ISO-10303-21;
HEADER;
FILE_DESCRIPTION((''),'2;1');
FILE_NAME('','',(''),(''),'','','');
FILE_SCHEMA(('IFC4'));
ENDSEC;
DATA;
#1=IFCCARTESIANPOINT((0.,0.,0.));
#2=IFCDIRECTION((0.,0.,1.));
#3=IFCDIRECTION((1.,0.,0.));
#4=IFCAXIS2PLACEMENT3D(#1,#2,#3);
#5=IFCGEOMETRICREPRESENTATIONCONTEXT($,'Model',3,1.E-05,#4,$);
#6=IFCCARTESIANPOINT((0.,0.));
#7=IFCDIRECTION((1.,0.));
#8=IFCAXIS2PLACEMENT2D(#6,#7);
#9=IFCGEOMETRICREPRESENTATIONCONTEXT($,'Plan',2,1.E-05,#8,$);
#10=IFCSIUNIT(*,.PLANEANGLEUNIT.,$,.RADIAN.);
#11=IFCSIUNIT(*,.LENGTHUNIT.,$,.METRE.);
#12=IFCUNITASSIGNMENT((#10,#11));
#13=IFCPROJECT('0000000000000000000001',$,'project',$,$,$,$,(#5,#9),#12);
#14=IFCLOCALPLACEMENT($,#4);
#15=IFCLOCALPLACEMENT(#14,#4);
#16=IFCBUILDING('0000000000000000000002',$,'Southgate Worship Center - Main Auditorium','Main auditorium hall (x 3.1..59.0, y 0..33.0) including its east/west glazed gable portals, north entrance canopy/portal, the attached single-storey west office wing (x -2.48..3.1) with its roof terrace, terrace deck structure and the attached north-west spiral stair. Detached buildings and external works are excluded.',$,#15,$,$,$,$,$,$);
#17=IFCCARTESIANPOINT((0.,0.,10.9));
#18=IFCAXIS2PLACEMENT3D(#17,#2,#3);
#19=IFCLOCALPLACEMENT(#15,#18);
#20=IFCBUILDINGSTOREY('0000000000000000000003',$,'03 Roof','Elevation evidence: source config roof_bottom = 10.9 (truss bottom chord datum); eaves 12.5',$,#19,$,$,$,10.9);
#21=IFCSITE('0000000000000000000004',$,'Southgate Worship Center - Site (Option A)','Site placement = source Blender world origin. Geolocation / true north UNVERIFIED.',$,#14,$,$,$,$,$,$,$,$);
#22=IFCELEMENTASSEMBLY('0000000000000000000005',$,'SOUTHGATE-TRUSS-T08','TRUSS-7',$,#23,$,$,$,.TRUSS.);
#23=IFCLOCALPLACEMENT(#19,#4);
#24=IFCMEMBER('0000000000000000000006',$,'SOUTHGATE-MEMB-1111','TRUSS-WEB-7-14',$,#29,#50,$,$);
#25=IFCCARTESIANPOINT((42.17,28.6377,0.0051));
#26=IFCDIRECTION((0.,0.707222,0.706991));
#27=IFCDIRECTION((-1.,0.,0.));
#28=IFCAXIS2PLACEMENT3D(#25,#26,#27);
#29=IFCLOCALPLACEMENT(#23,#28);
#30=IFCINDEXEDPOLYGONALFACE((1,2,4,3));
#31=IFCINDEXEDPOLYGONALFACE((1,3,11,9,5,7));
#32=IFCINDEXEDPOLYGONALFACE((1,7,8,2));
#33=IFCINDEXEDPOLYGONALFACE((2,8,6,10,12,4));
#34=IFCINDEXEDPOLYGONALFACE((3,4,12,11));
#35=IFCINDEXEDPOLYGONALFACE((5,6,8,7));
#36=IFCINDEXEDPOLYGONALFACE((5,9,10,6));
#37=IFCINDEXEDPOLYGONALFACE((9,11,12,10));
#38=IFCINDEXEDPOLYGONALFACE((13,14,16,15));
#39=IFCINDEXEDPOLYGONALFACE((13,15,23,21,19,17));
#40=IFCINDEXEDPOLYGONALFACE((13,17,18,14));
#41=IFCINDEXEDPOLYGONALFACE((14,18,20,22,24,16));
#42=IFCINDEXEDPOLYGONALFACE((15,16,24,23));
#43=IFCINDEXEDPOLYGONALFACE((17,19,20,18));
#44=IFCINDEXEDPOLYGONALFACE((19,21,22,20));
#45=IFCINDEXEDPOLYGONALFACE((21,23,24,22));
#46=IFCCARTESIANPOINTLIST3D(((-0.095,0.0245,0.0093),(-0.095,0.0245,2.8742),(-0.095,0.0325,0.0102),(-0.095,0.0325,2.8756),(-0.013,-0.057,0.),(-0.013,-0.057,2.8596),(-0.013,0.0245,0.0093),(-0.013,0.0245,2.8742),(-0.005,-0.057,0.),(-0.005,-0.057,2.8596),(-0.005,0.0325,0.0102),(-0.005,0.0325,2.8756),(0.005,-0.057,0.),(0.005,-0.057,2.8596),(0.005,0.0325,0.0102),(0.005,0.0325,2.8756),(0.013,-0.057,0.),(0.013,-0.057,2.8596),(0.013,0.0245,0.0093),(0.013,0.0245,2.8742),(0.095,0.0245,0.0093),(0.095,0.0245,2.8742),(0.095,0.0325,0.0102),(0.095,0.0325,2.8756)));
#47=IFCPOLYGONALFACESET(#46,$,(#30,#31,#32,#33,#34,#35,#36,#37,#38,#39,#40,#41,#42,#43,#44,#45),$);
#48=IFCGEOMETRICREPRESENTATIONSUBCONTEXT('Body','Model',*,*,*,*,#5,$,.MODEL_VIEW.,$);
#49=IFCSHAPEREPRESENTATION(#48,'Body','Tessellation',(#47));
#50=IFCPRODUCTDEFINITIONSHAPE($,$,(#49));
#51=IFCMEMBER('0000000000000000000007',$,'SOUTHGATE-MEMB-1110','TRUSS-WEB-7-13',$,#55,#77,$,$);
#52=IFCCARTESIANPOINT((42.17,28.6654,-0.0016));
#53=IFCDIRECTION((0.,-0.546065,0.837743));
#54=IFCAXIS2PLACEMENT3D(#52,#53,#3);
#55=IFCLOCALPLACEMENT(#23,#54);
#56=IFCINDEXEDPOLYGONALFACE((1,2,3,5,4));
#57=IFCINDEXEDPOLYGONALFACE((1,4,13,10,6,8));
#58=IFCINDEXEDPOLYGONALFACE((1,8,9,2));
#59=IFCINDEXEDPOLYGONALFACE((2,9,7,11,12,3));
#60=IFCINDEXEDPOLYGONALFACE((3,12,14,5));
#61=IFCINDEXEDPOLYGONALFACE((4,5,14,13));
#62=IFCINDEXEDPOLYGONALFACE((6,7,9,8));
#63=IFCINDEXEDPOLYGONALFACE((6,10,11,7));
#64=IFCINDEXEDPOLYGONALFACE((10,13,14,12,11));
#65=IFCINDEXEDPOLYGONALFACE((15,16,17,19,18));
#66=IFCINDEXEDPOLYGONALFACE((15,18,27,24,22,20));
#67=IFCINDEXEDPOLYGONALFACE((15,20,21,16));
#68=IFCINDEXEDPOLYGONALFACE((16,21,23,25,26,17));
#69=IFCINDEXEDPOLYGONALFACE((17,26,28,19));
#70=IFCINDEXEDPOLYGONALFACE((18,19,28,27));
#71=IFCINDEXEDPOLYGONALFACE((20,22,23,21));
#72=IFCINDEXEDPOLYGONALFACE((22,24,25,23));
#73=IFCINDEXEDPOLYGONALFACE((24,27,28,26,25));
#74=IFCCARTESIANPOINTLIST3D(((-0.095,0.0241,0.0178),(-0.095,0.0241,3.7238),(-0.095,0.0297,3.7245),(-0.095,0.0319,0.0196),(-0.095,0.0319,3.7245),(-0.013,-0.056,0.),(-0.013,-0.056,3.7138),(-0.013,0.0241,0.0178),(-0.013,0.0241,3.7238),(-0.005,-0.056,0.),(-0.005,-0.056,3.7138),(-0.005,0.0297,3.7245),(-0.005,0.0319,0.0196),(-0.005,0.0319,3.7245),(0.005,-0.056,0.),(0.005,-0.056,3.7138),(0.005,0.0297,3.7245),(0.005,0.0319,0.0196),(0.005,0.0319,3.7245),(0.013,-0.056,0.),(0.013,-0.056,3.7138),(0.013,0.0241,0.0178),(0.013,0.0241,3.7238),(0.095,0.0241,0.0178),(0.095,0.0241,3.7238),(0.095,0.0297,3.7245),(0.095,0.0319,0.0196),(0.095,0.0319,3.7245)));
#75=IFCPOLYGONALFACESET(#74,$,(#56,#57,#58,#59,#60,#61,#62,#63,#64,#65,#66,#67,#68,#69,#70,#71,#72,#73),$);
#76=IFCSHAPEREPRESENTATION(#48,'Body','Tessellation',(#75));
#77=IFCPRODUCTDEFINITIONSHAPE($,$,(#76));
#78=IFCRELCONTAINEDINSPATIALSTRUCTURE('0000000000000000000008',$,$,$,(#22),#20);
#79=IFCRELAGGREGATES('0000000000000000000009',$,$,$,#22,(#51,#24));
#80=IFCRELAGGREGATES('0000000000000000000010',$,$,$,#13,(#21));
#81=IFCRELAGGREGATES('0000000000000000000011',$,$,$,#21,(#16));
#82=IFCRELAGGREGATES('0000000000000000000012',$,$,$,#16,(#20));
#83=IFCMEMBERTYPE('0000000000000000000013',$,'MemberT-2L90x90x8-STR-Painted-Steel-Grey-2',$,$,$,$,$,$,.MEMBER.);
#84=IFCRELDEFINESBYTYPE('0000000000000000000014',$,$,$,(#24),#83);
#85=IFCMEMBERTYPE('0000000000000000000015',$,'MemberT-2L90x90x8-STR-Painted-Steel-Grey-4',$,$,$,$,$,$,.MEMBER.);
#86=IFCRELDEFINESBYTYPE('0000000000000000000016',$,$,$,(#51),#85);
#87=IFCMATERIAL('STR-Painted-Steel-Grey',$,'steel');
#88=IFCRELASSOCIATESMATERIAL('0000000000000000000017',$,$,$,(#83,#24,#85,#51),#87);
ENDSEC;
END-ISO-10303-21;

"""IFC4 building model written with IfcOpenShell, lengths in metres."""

from ifc_helpers import new_model, si_unit, frame, origin_with_axes, origin_2d_with_axis, place, context, subcontext, project, spatial, indexed_curve, outline, composite_profile, extrude, clip, halfspace, material, material_profile, profile_set, profile_usage, type_object, element, aggregate, save


model = new_model("IFC4")

# Units and contexts
model_context = context("Model", 3, precision=1e-05, world=origin_with_axes())
plan_context = context("Plan", 2, precision=1e-05, world=origin_2d_with_axis())
body_context = subcontext(model_context, "Body", "Model", "MODEL_VIEW")
ifc_project = project(units=[si_unit("PLANEANGLEUNIT", "RADIAN"), si_unit("LENGTHUNIT", "METRE")], contexts=[model_context, plan_context])

# Site, building, storey
site_placement = place(None, origin_with_axes())
site = spatial("IfcSite", under=ifc_project, at=site_placement, Name="Southgate Worship Center - Site (Option A)", Description="Site placement = source Blender world origin. Geolocation / true north UNVERIFIED.")
building_placement = place(site_placement, origin_with_axes())
building = spatial("IfcBuilding", under=site, at=building_placement, Name="Southgate Worship Center - Main Auditorium", Description="Main auditorium hall (x 3.1..59.0, y 0..33.0) including its east/west glazed gable portals, north entrance canopy/portal, the attached single-storey west office wing (x -2.48..3.1) with its roof terrace, terrace deck structure and the attached north-west spiral stair. Detached buildings and external works are excluded.")
storey_placement = place(building_placement, frame((0.0, 0.0, 10.9), z_axis=(0.0, 0.0, 1.0), x_axis=(1.0, 0.0, 0.0)))
storey = spatial("IfcBuildingStorey", under=building, at=storey_placement, Name="03 Roof", Description="Elevation evidence: source config roof_bottom = 10.9 (truss bottom chord datum); eaves 12.5", Elevation=10.9)

# Element assembly, members
assembly_1_placement = place(storey_placement, origin_with_axes())
assembly_1 = element("IfcElementAssembly", 1, at=assembly_1_placement, inside=storey, Name="SOUTHGATE-TRUSS-T08", Description="TRUSS-7", PredefinedType="TRUSS")
ifc_material_1 = material(Name="STR-Painted-Steel-Grey", Category="steel")
ifc_material_profile_1 = material_profile(ifc_material_1, composite_profile([outline(indexed_curve([(0.005, 0.0325), (0.005, -0.057), (0.013, -0.057), (0.013, 0.0245), (0.095, 0.0245), (0.095, 0.0325), (0.005, 0.0325)], self_intersect=False)), outline(indexed_curve([(-0.095, 0.0325), (-0.095, 0.0245), (-0.013, 0.0245), (-0.013, -0.057), (-0.005, -0.057), (-0.005, 0.0325), (-0.095, 0.0325)], self_intersect=False))]))
ifc_profile_set_1 = profile_set([ifc_material_profile_1], Name="MemberT-2L90x90x8-STR-Painted-Steel-Grey-2")
ifc_profile_usage_1 = profile_usage(ifc_profile_set_1)
member_type_1 = type_object("IfcMemberType", Name="MemberT-2L90x90x8-STR-Painted-Steel-Grey-2", PredefinedType="MEMBER", material=ifc_profile_set_1)
member_1_placement = place(assembly_1_placement, frame((42.17, 28.6377, 0.0051), z_axis=(0.0, 0.707222, 0.706991), x_axis=(-1.0, 0.0, 0.0)))
member_1 = element("IfcMember", 2, at=member_1_placement, type_object=member_type_1, material=ifc_profile_usage_1, Name="SOUTHGATE-MEMB-1111", Description="TRUSS-WEB-7-14", context=body_context, shape_type="Clipping", body=[
    clip(clip(extrude(composite_profile([outline(indexed_curve([(0.005, 0.0325), (0.005, -0.057), (0.013, -0.057), (0.013, 0.0245), (0.095, 0.0245), (0.095, 0.0325), (0.005, 0.0325)], self_intersect=False)), outline(indexed_curve([(-0.095, 0.0325), (-0.095, 0.0245), (-0.013, 0.0245), (-0.013, -0.057), (-0.005, -0.057), (-0.005, 0.0325), (-0.095, 0.0325)], self_intersect=False))]), origin_with_axes(), (0.0, 0.0, 1.0), 2.876), halfspace(frame((0.0377, 0.0, 0.0065), z_axis=(-0.000001, 0.112871, -0.99361), x_axis=(-1.0, -0.000008, 0.0)), False)), halfspace(frame((0.0377, 0.0, 2.8698), z_axis=(0.000001, -0.175303, 0.984514), x_axis=(1.0, 0.000006, 0.0)), False)),
])
ifc_material_profile_2 = material_profile(ifc_material_1, composite_profile([outline(indexed_curve([(0.005, 0.0319), (0.005, -0.056), (0.013, -0.056), (0.013, 0.0241), (0.095, 0.0241), (0.095, 0.0319), (0.005, 0.0319)], self_intersect=False)), outline(indexed_curve([(-0.095, 0.0319), (-0.095, 0.0241), (-0.013, 0.0241), (-0.013, -0.056), (-0.005, -0.056), (-0.005, 0.0319), (-0.095, 0.0319)], self_intersect=False))]))
ifc_profile_set_2 = profile_set([ifc_material_profile_2], Name="MemberT-2L90x90x8-STR-Painted-Steel-Grey-4")
ifc_profile_usage_2 = profile_usage(ifc_profile_set_2)
member_type_2 = type_object("IfcMemberType", Name="MemberT-2L90x90x8-STR-Painted-Steel-Grey-4", PredefinedType="MEMBER", material=ifc_profile_set_2)
member_2_placement = place(assembly_1_placement, frame((42.17, 28.6654, -0.0016), z_axis=(0.0, -0.546065, 0.837743), x_axis=(1.0, 0.0, 0.0)))
member_2 = element("IfcMember", 3, at=member_2_placement, type_object=member_type_2, material=ifc_profile_usage_2, Name="SOUTHGATE-MEMB-1110", Description="TRUSS-WEB-7-13", context=body_context, shape_type="Clipping", body=[
    clip(clip(extrude(composite_profile([outline(indexed_curve([(0.005, 0.0319), (0.005, -0.056), (0.013, -0.056), (0.013, 0.0241), (0.095, 0.0241), (0.095, 0.0319), (0.005, 0.0319)], self_intersect=False)), outline(indexed_curve([(-0.095, 0.0319), (-0.095, 0.0241), (-0.013, 0.0241), (-0.013, -0.056), (-0.005, -0.056), (-0.005, 0.0319), (-0.095, 0.0319)], self_intersect=False))]), origin_with_axes(), (0.0, 0.0, 1.0), 3.7245), halfspace(frame((-0.0377, 0.0, 0.0125), z_axis=(0.0, 0.217349, -0.976094), x_axis=(-1.0, 0.000001, 0.0)), False)), halfspace(frame((-0.0377, 0.0, 3.7208), z_axis=(0.0, -0.12415, 0.992263), x_axis=(1.0, -0.000003, 0.0)), False)),
])

aggregate(assembly_1, [member_2, member_1])

save(model, "model.ifc")
